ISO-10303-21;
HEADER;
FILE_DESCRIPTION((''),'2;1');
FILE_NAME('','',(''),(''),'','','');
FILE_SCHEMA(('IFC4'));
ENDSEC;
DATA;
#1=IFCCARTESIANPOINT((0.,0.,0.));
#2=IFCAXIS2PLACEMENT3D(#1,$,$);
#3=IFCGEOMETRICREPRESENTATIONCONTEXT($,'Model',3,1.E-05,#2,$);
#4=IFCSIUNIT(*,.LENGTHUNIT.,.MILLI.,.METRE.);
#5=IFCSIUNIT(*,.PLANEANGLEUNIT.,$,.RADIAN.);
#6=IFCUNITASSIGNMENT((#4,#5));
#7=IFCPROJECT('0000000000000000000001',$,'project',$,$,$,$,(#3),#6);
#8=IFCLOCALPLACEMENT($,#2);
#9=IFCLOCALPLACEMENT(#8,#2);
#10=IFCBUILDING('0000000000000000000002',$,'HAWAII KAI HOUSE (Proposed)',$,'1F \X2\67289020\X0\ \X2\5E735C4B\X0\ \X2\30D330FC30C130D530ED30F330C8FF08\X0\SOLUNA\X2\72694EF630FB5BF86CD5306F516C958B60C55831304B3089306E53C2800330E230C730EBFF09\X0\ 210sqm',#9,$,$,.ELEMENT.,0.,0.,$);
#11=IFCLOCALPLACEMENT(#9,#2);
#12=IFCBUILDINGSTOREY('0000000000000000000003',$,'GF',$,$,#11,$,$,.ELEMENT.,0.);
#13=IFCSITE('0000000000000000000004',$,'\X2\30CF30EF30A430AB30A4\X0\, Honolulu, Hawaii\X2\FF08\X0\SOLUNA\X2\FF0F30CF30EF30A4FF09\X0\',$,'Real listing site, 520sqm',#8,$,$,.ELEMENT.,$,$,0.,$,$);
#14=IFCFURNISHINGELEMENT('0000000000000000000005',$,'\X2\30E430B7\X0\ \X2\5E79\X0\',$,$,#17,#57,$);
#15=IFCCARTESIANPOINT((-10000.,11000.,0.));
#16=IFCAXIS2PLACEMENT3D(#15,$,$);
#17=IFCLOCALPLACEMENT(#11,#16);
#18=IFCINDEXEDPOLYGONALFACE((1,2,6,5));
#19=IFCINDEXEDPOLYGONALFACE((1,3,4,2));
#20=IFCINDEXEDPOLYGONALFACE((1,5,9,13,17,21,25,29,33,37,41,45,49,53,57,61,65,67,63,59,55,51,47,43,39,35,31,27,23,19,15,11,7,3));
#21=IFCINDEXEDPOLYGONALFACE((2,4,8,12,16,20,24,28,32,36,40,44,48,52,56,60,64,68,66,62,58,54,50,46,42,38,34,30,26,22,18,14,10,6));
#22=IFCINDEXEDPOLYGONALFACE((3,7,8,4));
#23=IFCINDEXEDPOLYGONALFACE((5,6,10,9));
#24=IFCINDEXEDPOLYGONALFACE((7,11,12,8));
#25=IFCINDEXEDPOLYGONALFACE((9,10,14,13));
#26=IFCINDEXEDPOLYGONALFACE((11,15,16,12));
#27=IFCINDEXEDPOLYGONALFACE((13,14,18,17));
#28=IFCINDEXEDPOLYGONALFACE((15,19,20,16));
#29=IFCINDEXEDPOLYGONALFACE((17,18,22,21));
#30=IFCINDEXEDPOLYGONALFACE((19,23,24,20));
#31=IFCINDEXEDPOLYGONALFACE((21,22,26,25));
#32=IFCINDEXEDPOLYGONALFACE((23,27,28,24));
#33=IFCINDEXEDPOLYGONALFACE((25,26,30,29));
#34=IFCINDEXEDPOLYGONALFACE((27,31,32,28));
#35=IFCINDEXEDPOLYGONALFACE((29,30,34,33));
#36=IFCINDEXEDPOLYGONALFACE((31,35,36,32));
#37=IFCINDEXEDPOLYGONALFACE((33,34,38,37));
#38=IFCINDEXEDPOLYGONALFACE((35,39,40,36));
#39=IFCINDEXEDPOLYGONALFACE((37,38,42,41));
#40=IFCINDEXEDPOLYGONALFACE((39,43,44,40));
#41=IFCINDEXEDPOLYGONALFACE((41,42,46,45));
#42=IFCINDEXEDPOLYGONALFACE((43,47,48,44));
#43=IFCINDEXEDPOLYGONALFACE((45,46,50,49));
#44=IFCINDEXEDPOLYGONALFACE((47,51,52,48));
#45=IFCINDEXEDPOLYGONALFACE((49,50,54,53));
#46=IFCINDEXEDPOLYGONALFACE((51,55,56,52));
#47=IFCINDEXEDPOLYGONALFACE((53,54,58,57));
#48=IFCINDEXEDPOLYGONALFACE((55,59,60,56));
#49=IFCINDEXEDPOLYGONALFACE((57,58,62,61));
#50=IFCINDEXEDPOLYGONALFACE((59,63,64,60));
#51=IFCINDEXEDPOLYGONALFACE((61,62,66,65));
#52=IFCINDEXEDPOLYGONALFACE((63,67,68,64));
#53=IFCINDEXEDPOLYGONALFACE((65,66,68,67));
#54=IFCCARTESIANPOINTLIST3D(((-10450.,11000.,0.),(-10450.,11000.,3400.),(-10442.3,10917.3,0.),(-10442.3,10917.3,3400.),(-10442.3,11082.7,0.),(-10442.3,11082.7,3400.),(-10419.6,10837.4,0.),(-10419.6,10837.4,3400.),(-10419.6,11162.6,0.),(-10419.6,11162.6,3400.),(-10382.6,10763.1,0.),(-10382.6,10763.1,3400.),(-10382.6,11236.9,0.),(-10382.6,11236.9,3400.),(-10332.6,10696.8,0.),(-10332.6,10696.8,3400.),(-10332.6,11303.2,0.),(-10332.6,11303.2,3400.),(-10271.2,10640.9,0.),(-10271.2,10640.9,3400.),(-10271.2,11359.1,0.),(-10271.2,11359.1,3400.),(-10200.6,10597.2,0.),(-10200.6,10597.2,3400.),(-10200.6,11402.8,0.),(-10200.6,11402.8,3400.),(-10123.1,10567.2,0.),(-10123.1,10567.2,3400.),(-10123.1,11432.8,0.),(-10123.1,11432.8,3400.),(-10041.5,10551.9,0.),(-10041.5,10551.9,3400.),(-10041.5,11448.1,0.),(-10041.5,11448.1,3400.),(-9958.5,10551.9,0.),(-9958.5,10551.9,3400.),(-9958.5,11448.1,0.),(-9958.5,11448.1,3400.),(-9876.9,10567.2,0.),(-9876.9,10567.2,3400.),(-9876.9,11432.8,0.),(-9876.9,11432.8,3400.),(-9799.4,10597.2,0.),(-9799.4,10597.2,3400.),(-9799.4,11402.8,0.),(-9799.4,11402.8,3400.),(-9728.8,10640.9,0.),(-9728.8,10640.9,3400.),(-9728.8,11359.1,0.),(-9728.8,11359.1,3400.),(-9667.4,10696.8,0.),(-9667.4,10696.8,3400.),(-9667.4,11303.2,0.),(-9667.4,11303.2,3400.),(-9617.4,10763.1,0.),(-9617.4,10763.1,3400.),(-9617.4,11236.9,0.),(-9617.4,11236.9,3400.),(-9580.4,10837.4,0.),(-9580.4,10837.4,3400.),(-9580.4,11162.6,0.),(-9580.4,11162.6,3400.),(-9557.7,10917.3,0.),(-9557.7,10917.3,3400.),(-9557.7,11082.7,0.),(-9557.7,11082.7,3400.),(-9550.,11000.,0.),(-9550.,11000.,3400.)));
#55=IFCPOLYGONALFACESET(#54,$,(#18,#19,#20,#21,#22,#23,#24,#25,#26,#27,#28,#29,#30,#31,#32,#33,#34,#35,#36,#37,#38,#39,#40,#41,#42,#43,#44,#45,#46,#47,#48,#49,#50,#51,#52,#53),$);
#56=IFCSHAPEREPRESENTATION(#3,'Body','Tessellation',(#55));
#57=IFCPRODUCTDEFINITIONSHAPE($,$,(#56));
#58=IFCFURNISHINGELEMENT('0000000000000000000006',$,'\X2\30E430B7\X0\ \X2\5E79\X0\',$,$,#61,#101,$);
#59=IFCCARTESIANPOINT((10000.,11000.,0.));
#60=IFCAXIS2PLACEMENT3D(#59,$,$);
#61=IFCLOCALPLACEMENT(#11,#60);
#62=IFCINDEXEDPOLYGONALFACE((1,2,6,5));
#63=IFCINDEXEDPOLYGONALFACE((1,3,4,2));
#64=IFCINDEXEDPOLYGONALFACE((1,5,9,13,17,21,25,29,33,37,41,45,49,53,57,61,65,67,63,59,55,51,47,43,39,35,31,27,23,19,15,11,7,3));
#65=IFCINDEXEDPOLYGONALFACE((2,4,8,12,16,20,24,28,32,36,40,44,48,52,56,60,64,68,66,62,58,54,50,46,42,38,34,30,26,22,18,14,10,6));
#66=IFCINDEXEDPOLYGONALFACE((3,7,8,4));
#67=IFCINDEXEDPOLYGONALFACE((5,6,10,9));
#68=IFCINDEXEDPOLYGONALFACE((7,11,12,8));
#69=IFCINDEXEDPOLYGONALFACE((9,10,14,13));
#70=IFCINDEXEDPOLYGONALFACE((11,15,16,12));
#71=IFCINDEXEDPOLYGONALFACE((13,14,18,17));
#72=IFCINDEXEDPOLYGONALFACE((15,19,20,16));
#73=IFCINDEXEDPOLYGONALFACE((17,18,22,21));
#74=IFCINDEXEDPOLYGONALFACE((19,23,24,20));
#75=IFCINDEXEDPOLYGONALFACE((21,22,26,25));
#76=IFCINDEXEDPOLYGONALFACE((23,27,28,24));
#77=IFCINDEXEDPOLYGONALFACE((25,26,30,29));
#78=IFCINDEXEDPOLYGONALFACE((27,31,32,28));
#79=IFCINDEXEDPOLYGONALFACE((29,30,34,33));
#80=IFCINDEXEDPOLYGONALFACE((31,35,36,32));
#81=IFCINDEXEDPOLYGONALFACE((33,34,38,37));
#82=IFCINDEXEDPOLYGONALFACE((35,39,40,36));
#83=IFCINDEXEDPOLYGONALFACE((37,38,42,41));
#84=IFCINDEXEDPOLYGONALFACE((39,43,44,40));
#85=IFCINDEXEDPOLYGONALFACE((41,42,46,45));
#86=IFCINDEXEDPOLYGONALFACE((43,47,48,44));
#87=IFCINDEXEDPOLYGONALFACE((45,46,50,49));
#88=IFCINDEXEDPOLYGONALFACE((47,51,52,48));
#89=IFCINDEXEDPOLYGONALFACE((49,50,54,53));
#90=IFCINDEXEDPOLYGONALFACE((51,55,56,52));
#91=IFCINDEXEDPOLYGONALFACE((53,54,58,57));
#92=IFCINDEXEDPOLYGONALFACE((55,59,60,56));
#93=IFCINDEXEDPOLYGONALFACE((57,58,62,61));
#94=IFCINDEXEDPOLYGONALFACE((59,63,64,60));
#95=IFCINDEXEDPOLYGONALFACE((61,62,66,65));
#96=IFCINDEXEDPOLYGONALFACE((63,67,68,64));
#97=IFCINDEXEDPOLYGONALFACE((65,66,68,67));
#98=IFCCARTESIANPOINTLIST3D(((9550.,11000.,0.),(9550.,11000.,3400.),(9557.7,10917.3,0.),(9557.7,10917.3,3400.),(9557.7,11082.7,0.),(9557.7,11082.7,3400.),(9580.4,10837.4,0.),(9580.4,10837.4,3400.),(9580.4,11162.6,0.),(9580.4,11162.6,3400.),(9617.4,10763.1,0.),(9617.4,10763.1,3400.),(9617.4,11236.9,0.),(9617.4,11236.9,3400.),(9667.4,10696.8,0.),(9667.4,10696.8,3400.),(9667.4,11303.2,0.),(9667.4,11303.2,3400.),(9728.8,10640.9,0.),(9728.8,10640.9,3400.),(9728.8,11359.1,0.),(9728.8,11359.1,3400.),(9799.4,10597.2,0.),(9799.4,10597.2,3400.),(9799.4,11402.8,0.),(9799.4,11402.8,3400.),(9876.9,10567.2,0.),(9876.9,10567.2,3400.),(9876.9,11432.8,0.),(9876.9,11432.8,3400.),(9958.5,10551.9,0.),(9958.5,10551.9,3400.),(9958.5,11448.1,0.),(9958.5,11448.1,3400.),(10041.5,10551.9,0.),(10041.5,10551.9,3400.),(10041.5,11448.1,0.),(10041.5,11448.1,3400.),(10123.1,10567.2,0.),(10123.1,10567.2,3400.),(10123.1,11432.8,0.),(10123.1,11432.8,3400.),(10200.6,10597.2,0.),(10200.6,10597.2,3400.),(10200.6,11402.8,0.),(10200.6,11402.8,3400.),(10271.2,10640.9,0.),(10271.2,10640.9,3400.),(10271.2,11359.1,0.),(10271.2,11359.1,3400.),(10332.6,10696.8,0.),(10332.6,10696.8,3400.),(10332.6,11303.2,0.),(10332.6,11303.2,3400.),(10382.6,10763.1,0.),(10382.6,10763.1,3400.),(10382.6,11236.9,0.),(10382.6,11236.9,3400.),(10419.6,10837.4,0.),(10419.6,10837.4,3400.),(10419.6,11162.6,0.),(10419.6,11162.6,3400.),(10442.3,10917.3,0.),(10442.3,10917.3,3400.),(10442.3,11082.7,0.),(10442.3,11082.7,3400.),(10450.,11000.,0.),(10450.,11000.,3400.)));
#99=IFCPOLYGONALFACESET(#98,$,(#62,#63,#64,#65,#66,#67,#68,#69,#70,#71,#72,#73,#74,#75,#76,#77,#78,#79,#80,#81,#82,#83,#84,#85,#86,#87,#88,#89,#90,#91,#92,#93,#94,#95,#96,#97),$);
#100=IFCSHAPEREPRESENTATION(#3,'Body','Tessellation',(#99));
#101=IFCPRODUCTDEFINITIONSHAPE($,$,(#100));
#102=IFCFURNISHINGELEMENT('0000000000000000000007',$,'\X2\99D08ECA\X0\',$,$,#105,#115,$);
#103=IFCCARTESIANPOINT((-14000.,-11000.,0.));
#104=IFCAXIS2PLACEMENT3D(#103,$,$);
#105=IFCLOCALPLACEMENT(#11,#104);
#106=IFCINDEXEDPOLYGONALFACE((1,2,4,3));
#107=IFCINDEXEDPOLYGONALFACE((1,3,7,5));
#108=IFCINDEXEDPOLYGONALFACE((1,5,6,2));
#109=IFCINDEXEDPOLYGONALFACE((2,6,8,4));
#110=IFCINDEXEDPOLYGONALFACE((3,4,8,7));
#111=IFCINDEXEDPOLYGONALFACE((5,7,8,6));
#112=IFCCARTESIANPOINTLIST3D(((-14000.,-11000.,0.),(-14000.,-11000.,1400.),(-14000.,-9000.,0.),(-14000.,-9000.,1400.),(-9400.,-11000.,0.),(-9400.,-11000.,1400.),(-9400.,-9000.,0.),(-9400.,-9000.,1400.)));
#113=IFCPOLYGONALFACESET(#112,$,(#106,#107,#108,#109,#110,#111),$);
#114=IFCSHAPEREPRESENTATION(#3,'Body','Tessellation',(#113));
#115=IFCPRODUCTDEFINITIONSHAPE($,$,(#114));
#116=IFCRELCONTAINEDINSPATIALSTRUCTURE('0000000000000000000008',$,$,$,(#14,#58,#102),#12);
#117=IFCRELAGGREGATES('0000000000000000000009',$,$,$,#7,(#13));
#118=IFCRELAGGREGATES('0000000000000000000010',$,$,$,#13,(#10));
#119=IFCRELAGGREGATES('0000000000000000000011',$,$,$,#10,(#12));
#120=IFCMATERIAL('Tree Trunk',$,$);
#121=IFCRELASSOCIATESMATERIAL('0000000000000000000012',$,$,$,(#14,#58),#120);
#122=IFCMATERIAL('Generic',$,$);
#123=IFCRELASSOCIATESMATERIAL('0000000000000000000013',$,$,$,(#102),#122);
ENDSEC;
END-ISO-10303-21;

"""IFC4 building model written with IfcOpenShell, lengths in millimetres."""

from ifc_helpers import new_model, si_unit, frame, frame_2d, origin, origin_2d, place, context, project, spatial, rectangle, circle, extrude, material, element, save


model = new_model("IFC4")

# Units and contexts
model_context = context("Model", 3, precision=1e-05, world=origin())
ifc_project = project(units=[si_unit("LENGTHUNIT", "METRE", prefix="MILLI"), si_unit("PLANEANGLEUNIT", "RADIAN")], contexts=[model_context])

# Site, building, storey
site_placement = place(None, origin())
site = spatial("IfcSite", under=ifc_project, at=site_placement, Name="ハワイカイ, Honolulu, Hawaii（SOLUNA／ハワイ）", ObjectType="Real listing site, 520sqm", CompositionType="ELEMENT", RefElevation=0.0)
building_placement = place(site_placement, origin())
building = spatial("IfcBuilding", under=site, at=building_placement, Name="HAWAII KAI HOUSE (Proposed)", ObjectType="1F 木造 平屋 ビーチフロント（SOLUNA物件・寸法は公開情報からの参考モデル） 210sqm", CompositionType="ELEMENT", ElevationOfRefHeight=0.0, ElevationOfTerrain=0.0)
storey_placement = place(building_placement, origin())
storey = spatial("IfcBuildingStorey", under=building, at=storey_placement, Name="GF", CompositionType="ELEMENT", Elevation=0.0)

# Shared definitions
ifc_material_1 = material(Name="Generic")

# Furnishing elements
ifc_material_2 = material(Name="Tree Trunk")
furnishing_1_placement = place(storey_placement, frame((-10000.0, 11000.0, 0.0)))
element("IfcFurnishingElement", 1, at=furnishing_1_placement, inside=storey, material=ifc_material_2, Name="ヤシ 幹", context=model_context, shape_type="SweptSolid", body=[
    extrude(circle(Radius=450.0, at=origin_2d()), frame((-10000.0, 11000.0, 0.0)), (0.0, 0.0, 1.0), 3400.0),
])
furnishing_2_placement = place(storey_placement, frame((10000.0, 11000.0, 0.0)))
element("IfcFurnishingElement", 2, at=furnishing_2_placement, inside=storey, material=ifc_material_2, Name="ヤシ 幹", context=model_context, shape_type="SweptSolid", body=[
    extrude(circle(Radius=450.0, at=origin_2d()), frame((10000.0, 11000.0, 0.0)), (0.0, 0.0, 1.0), 3400.0),
])
furnishing_3_placement = place(storey_placement, frame((-14000.0, -11000.0, 0.0)))
element("IfcFurnishingElement", 3, at=furnishing_3_placement, inside=storey, material=ifc_material_1, Name="駐車", context=model_context, shape_type="SweptSolid", body=[
    extrude(rectangle(XDim=4600.0, YDim=2000.0, at=frame_2d((2300.0, 1000.0))), frame((-14000.0, -11000.0, 0.0)), (0.0, 0.0, 1.0), 1400.0),
])

save(model, "model.ifc")
